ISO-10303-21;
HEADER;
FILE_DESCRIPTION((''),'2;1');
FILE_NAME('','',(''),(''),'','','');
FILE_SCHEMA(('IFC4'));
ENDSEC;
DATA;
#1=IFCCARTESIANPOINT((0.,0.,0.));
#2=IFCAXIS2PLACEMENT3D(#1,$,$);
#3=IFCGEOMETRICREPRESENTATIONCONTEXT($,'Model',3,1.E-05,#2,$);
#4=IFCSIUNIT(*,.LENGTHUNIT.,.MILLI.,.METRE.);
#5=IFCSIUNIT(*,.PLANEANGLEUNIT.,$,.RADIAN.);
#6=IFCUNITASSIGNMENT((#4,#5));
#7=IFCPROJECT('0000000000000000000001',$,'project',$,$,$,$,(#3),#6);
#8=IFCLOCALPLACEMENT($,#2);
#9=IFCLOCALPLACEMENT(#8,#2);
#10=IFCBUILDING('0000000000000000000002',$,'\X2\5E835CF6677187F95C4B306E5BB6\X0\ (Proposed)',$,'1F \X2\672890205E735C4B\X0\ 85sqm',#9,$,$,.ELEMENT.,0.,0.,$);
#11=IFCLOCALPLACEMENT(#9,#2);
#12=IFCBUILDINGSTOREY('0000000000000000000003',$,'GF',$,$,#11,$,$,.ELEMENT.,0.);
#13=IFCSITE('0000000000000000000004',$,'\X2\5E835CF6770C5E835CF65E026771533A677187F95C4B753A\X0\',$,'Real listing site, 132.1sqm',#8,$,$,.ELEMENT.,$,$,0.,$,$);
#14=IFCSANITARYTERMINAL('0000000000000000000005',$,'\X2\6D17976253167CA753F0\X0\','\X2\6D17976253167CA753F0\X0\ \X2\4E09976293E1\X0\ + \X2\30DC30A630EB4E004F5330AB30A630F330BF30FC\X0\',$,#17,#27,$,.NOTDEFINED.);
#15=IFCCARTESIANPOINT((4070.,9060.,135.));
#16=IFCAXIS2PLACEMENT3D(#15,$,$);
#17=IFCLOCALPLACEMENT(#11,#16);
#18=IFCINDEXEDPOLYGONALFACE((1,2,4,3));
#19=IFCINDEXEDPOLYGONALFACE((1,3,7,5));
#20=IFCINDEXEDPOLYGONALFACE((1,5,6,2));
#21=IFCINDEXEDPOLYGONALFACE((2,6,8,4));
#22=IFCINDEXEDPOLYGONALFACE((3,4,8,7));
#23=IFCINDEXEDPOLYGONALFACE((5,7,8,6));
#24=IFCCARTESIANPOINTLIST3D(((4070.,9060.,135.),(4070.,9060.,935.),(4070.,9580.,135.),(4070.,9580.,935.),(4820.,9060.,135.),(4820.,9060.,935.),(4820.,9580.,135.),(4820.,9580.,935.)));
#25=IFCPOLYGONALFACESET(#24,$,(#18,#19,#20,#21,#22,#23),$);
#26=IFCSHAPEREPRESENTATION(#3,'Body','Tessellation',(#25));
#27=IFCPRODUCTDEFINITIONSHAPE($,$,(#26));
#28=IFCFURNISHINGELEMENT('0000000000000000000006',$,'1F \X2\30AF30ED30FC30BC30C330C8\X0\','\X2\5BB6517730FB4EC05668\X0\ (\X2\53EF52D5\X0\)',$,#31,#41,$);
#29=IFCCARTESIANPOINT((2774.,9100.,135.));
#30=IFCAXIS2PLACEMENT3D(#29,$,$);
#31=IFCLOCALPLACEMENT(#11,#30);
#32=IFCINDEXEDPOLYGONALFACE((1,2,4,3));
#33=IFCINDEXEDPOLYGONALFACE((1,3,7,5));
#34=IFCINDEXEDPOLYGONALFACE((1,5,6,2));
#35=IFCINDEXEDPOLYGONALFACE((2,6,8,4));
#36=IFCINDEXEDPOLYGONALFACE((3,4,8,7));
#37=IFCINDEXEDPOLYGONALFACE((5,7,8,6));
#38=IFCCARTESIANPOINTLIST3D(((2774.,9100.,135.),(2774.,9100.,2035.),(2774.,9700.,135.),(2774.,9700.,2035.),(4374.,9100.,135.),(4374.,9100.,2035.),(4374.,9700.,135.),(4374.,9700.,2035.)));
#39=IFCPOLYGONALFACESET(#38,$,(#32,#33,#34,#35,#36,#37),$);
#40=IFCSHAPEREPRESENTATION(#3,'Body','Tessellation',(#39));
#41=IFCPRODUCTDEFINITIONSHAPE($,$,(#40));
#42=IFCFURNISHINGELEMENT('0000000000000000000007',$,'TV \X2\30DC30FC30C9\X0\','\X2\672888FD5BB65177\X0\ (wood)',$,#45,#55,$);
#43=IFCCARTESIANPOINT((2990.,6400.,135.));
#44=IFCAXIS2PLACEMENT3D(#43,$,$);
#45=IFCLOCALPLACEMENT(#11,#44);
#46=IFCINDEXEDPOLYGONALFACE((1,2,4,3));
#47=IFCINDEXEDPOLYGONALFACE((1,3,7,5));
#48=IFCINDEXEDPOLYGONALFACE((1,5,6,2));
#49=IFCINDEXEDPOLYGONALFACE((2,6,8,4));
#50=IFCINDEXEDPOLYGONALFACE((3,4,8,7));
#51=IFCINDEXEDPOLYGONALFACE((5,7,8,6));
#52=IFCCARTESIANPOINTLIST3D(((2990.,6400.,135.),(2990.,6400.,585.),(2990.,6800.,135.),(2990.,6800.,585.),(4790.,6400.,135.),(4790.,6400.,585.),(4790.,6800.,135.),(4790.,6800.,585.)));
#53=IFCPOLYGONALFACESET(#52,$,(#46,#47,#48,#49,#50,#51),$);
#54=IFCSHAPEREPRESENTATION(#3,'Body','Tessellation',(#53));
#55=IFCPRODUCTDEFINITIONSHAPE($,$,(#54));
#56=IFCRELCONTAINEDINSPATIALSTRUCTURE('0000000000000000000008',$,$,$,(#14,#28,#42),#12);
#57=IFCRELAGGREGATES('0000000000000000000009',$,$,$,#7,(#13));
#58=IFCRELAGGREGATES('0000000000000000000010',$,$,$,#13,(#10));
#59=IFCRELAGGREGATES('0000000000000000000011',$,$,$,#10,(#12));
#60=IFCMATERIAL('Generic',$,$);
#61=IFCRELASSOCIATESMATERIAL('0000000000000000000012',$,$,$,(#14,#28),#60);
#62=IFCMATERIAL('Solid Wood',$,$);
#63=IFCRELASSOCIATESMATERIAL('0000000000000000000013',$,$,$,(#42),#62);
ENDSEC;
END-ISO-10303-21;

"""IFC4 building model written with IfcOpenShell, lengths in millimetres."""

from ifc_helpers import new_model, si_unit, frame, frame_2d, origin, place, context, project, spatial, rectangle, extrude, material, element, save


model = new_model("IFC4")

# Units and contexts
model_context = context("Model", 3, precision=1e-05, world=origin())
ifc_project = project(units=[si_unit("LENGTHUNIT", "METRE", prefix="MILLI"), si_unit("PLANEANGLEUNIT", "RADIAN")], contexts=[model_context])

# Site, building, storey
site_placement = place(None, origin())
site = spatial("IfcSite", under=ifc_project, at=site_placement, Name="広島県広島市東区東蟹屋町", ObjectType="Real listing site, 132.1sqm", CompositionType="ELEMENT", RefElevation=0.0)
building_placement = place(site_placement, origin())
building = spatial("IfcBuilding", under=site, at=building_placement, Name="広島東蟹屋の家 (Proposed)", ObjectType="1F 木造平屋 85sqm", CompositionType="ELEMENT", ElevationOfRefHeight=0.0, ElevationOfTerrain=0.0)
storey_placement = place(building_placement, origin())
storey = spatial("IfcBuildingStorey", under=building, at=storey_placement, Name="GF", CompositionType="ELEMENT", Elevation=0.0)

# Shared definitions
ifc_material_1 = material(Name="Solid Wood")

# Shared definitions
ifc_material_2 = material(Name="Generic")

# Sanitary terminal
sanitary_terminal_1_placement = place(storey_placement, frame((4070.0, 9060.0, 135.0)))
element("IfcSanitaryTerminal", 1, at=sanitary_terminal_1_placement, inside=storey, material=ifc_material_2, Name="洗面化粧台", Description="洗面化粧台 三面鏡 + ボウル一体カウンター", PredefinedType="NOTDEFINED", context=model_context, shape_type="SweptSolid", body=[
    extrude(rectangle(XDim=750.0, YDim=520.0, at=frame_2d((375.0, 260.0))), frame((4070.0, 9060.0, 135.0)), (0.0, 0.0, 1.0), 800.0),
])

# Furnishing elements
furnishing_1_placement = place(storey_placement, frame((2774.0, 9100.0, 135.0)))
element("IfcFurnishingElement", 2, at=furnishing_1_placement, inside=storey, material=ifc_material_2, Name="1F クローゼット", Description="家具・什器 (可動)", context=model_context, shape_type="SweptSolid", body=[
    extrude(rectangle(XDim=1600.0, YDim=600.0, at=frame_2d((800.0, 300.0))), frame((2774.0, 9100.0, 135.0)), (0.0, 0.0, 1.0), 1900.0),
])
furnishing_2_placement = place(storey_placement, frame((2990.0, 6400.0, 135.0)))
element("IfcFurnishingElement", 3, at=furnishing_2_placement, inside=storey, material=ifc_material_1, Name="TV ボード", Description="木製家具 (wood)", context=model_context, shape_type="SweptSolid", body=[
    extrude(rectangle(XDim=1800.0, YDim=400.0, at=frame_2d((900.0, 200.0))), frame((2990.0, 6400.0, 135.0)), (0.0, 0.0, 1.0), 450.0),
])

save(model, "model.ifc")
